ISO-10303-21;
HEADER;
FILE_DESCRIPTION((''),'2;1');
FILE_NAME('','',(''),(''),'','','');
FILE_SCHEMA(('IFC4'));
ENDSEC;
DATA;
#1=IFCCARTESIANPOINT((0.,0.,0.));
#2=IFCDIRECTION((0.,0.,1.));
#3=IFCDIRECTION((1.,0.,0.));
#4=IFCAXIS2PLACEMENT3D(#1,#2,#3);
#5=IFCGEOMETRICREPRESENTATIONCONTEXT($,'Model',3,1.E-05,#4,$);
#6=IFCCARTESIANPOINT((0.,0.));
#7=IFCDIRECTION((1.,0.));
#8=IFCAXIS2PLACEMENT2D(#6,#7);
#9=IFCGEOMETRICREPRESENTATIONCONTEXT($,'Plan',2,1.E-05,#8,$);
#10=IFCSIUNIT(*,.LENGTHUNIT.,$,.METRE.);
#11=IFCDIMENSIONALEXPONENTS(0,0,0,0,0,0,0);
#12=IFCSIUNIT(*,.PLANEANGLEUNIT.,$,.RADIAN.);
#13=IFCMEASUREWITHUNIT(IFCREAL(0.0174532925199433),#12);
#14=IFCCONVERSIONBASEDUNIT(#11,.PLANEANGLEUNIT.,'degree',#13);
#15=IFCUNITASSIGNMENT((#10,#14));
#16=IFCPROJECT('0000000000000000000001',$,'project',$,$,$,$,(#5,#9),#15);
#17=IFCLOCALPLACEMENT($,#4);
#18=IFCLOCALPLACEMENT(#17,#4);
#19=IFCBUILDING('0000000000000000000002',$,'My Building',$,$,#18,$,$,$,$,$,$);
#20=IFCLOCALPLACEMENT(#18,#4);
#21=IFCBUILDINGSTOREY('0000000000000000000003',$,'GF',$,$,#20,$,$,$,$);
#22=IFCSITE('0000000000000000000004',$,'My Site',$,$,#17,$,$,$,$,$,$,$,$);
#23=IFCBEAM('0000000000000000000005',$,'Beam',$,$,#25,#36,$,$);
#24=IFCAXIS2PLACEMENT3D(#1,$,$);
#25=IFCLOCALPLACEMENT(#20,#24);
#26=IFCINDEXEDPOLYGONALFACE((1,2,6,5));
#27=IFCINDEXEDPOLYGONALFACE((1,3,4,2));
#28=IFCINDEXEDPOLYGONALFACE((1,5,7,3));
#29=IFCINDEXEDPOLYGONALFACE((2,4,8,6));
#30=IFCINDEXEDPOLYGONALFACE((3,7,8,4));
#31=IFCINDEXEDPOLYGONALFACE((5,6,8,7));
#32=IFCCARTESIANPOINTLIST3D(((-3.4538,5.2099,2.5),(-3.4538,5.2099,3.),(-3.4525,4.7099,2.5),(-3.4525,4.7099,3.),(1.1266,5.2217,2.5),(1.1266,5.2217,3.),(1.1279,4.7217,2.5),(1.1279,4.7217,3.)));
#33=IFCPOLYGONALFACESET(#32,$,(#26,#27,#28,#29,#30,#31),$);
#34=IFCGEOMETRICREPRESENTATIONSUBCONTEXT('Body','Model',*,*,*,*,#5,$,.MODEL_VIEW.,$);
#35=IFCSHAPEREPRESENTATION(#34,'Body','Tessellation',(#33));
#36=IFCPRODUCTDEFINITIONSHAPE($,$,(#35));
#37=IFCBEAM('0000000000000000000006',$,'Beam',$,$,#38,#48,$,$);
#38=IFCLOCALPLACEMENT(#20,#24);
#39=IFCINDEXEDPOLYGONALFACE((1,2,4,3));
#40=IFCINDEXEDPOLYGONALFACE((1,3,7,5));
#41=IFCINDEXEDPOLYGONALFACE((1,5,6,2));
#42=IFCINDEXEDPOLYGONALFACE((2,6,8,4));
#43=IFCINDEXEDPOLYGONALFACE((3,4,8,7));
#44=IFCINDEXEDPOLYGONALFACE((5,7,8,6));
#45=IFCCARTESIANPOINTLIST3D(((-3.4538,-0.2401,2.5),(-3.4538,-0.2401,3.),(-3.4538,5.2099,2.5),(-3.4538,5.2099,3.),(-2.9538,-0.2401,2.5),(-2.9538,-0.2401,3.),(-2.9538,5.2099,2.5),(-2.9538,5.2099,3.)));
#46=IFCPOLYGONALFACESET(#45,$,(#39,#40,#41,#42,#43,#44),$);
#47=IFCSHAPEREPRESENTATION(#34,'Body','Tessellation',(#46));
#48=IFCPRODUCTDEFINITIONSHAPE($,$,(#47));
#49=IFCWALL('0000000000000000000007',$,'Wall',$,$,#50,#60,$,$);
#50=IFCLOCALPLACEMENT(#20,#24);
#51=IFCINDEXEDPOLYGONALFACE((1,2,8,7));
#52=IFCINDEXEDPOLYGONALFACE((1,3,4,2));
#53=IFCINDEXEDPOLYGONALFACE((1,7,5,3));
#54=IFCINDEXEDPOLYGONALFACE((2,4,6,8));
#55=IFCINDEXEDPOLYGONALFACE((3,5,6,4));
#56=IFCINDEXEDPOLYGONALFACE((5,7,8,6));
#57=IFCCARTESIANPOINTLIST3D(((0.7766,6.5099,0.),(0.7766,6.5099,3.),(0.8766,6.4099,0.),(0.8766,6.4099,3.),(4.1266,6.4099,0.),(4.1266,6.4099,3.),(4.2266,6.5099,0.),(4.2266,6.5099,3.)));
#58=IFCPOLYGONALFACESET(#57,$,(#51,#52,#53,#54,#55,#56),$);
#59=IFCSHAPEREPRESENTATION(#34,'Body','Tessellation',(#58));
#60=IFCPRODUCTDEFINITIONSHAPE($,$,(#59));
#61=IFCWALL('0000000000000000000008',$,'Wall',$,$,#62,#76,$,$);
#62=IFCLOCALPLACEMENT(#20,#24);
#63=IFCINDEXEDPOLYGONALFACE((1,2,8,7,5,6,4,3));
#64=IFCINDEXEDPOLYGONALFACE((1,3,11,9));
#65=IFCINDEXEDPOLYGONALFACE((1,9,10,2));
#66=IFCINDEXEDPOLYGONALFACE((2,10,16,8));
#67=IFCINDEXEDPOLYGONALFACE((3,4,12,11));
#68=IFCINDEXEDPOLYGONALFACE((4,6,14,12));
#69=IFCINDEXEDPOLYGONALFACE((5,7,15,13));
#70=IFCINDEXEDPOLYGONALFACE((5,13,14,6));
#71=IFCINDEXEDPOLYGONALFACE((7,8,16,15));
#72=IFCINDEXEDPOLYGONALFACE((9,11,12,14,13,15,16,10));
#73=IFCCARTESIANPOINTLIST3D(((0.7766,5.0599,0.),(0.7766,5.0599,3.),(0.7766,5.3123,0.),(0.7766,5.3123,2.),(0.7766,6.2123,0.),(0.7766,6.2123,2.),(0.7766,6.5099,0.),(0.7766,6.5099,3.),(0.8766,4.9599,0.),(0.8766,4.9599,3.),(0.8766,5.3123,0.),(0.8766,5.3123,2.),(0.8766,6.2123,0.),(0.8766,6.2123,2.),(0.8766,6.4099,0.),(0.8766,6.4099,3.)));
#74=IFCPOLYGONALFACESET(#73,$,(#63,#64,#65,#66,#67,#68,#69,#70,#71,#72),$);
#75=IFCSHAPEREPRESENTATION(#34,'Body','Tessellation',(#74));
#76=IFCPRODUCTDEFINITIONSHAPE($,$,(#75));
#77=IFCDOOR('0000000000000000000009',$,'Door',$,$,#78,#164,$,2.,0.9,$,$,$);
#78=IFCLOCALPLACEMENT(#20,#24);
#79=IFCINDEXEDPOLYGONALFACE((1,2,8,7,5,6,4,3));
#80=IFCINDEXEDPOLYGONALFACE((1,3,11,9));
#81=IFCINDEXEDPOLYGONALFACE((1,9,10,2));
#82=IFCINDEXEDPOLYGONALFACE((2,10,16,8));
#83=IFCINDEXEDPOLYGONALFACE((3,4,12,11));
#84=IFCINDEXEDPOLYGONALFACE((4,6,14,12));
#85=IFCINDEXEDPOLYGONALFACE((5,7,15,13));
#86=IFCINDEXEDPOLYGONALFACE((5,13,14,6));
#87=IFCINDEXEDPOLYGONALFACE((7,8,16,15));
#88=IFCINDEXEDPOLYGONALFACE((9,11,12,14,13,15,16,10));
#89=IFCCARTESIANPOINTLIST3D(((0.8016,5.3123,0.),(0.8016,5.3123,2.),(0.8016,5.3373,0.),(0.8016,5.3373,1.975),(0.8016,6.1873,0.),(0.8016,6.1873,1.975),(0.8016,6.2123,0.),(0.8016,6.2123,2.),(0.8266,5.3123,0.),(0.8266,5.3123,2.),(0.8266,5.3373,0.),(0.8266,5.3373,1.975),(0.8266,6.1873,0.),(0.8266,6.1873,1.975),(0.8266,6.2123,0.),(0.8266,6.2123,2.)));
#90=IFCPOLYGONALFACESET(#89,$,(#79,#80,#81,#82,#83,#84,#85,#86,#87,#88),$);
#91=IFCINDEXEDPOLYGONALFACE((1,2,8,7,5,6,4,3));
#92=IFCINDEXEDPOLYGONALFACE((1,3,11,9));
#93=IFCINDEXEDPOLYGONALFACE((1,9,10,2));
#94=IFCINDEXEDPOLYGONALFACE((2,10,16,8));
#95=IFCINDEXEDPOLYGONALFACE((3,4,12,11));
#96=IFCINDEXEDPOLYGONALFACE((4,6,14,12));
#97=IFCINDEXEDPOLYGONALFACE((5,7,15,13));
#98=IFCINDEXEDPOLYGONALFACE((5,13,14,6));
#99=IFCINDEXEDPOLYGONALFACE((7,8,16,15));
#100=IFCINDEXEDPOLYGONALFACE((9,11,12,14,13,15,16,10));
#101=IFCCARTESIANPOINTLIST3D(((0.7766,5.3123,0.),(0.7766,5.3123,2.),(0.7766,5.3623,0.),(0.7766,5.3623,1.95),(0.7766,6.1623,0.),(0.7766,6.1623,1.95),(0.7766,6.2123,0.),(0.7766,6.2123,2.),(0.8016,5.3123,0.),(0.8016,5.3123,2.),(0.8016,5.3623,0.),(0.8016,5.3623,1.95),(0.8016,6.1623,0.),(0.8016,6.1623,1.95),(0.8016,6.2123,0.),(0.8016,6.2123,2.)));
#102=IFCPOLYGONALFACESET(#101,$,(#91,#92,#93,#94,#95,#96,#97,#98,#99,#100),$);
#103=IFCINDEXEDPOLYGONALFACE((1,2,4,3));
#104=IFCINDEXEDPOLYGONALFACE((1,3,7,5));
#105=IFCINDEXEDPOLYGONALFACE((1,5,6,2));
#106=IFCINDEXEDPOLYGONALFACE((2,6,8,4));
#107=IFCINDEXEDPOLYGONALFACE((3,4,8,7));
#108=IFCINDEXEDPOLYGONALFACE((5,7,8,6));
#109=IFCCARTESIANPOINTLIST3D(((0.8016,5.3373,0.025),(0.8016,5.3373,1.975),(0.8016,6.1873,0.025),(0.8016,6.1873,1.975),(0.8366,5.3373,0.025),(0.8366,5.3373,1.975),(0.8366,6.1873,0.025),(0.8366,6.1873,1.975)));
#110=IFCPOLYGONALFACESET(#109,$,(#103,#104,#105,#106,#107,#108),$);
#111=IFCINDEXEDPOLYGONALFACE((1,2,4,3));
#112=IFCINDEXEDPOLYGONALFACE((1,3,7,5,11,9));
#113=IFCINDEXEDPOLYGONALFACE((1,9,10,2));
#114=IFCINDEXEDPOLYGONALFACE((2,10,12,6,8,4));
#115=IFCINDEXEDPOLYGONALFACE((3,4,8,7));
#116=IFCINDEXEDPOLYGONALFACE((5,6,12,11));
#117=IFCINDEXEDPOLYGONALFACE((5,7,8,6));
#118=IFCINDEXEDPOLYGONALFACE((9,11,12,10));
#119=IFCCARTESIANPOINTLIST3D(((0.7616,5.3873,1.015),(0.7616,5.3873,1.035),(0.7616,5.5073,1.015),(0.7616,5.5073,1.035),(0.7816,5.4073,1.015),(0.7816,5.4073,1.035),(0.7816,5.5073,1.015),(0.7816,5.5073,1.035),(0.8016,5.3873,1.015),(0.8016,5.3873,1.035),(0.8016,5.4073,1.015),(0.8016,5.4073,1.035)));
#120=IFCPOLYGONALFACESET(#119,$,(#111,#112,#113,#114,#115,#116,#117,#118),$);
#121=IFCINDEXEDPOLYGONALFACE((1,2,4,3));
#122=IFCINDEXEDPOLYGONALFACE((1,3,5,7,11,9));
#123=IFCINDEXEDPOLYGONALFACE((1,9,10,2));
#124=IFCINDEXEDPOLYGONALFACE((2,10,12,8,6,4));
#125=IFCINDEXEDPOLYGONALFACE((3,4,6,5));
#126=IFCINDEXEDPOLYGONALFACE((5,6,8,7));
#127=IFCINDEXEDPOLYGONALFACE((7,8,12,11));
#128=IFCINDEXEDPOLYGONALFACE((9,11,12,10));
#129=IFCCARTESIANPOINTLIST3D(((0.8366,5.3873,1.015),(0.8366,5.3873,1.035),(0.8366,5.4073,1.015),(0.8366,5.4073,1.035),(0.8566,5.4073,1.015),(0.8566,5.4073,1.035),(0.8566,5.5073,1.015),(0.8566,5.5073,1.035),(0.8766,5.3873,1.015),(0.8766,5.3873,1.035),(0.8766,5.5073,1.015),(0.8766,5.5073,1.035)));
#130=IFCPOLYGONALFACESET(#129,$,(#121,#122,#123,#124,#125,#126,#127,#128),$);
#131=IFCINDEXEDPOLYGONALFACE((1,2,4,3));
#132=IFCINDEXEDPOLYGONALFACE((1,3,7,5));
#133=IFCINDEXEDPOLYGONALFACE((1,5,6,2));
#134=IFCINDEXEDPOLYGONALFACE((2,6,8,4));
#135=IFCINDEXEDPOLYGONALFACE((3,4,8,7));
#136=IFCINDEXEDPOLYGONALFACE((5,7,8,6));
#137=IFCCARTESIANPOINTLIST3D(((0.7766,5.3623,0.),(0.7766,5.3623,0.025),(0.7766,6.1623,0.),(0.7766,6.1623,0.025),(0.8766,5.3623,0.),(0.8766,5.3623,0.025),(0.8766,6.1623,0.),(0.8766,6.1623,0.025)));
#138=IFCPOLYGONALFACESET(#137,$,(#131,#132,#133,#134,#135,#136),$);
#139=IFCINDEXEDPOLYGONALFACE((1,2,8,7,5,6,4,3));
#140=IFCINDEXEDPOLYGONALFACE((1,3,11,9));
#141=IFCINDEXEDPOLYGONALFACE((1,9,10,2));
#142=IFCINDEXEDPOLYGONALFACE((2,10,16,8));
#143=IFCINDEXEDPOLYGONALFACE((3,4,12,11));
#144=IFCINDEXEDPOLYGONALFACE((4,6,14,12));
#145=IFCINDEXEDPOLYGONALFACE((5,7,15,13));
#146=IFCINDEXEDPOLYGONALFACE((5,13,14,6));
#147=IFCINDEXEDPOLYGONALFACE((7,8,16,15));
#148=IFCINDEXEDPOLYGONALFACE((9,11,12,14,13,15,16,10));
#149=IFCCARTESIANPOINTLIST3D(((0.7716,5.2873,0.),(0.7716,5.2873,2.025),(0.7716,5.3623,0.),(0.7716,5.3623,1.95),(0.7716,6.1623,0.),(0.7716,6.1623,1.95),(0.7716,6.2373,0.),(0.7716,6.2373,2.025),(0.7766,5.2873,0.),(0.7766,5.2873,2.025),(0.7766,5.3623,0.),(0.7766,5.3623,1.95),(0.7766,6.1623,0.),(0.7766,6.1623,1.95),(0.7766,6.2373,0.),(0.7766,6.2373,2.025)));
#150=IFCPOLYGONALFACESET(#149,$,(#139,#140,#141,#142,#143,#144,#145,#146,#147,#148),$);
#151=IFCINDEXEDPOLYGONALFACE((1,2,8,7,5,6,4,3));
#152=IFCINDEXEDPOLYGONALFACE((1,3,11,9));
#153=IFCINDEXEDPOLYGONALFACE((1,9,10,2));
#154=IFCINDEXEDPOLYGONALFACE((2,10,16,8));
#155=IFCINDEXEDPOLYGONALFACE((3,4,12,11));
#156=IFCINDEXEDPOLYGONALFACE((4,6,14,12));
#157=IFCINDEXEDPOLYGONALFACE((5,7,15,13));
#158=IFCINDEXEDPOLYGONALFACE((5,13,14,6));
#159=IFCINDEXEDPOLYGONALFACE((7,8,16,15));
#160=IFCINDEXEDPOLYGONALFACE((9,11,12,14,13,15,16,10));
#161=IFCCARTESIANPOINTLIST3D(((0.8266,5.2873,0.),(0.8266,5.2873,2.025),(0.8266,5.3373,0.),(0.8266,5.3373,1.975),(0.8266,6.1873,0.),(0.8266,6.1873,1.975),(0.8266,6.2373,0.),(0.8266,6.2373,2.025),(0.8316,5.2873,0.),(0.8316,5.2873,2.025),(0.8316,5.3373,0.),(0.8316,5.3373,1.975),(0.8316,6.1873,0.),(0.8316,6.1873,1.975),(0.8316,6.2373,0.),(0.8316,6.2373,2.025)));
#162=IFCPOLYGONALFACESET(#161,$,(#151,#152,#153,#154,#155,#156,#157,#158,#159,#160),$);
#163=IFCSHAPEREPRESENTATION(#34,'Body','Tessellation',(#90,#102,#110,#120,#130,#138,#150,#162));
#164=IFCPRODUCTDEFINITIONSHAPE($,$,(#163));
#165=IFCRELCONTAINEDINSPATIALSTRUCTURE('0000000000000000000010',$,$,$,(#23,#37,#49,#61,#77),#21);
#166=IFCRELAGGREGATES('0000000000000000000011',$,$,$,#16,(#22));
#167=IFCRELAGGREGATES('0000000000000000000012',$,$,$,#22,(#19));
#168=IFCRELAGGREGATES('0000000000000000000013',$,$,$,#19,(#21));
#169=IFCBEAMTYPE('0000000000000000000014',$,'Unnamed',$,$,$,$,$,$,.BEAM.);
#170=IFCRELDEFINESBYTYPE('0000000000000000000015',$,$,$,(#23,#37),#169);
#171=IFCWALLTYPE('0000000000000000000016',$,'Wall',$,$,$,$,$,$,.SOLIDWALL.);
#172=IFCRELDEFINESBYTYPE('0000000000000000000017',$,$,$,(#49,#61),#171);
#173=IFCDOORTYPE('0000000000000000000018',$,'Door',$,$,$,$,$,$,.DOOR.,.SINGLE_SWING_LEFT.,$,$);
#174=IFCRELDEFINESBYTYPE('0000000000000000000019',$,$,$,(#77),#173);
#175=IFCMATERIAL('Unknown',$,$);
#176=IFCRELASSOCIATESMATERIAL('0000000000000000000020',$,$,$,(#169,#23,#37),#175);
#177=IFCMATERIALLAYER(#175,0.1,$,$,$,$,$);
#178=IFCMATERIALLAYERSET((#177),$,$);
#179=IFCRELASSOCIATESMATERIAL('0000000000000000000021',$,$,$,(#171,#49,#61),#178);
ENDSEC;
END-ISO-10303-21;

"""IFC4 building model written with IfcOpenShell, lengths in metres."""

from ifc_helpers import new_model, entity, si_unit, converted_unit, frame, origin_with_axes, origin_2d_with_axis, place, context, subcontext, project, spatial, line, indexed_curve, rectangle, outline, extrude, shape, source, transform, mapped, material, layer, layer_set, layer_usage, material_profile, profile_set, profile_usage, type_object, type_shapes, element, fill, save


model = new_model("IFC4")

# Units and contexts
model_context = context("Model", 3, precision=1e-05, world=origin_with_axes())
plan_context = context("Plan", 2, precision=1e-05, world=origin_2d_with_axis())
body_context_1 = subcontext(model_context, "Body", "Model", "MODEL_VIEW")
body_context_2 = subcontext(plan_context, "Body", "Plan", "PLAN_VIEW")
ifc_project = project(units=[si_unit("LENGTHUNIT", "METRE"), converted_unit("PLANEANGLEUNIT", "degree", entity("IfcReal", 0.0174532925199433), si_unit("PLANEANGLEUNIT", "RADIAN"), dimensions=[0, 0, 0, 0, 0, 0, 0])], contexts=[model_context, plan_context])

# Site, building, storey
site_placement = place(None, origin_with_axes())
site = spatial("IfcSite", under=ifc_project, at=site_placement, Name="My Site")
building_placement = place(site_placement, origin_with_axes())
building = spatial("IfcBuilding", under=site, at=building_placement, Name="My Building")
storey_placement = place(building_placement, origin_with_axes())
storey = spatial("IfcBuildingStorey", under=building, at=storey_placement, Name="GF")

# Shared definitions
ifc_material = material(Name="Unknown")

# Beams
ifc_material_profile_1 = material_profile(ifc_material, rectangle(XDim=0.5, YDim=0.5))
ifc_profile_set_1 = profile_set([ifc_material_profile_1])
beam_type = type_object("IfcBeamType", Name="Unnamed", PredefinedType="BEAM", material=ifc_profile_set_1)
ifc_profile_usage_1 = profile_usage(ifc_profile_set_1, cardinal=7)
beam_1_placement = place(storey_placement, frame((-3.4538, 5.2099, 3.0), z_axis=(0.999997, 0.002582, 0.0), x_axis=(-0.002582, 0.999997, 0.0)))
element("IfcBeam", 1, at=beam_1_placement, inside=storey, type_object=beam_type, material=ifc_profile_usage_1, Name="Beam", context=body_context_1, shape_type="SweptSolid", body=[
    extrude(rectangle(XDim=0.5, YDim=0.5), frame((-0.25, -0.25, 0.0), z_axis=(0.0, 0.0, 1.0), x_axis=(1.0, 0.0, 0.0)), (0.0, 0.0, 1.0), 4.5805),
])
ifc_profile_usage_2 = profile_usage(ifc_profile_set_1, cardinal=7)
beam_2_placement = place(storey_placement, frame((-2.9538, 5.2099, 3.0), z_axis=(0.0, -1.0, 0.0), x_axis=(1.0, 0.0, 0.0)))
element("IfcBeam", 2, at=beam_2_placement, inside=storey, type_object=beam_type, material=ifc_profile_usage_2, Name="Beam", context=body_context_1, shape_type="SweptSolid", body=[
    extrude(rectangle(XDim=0.5, YDim=0.5), frame((-0.25, -0.25, 0.0), z_axis=(0.0, 0.0, 1.0), x_axis=(1.0, 0.0, 0.0)), (0.0, 0.0, 1.0), 5.45),
])

# Wall
ifc_layer = layer(ifc_material, 0.1)
ifc_layer_set = layer_set([ifc_layer])
ifc_layer_usage_1 = layer_usage(ifc_layer_set, "AXIS2", "POSITIVE", 0.0)
wall_type = type_object("IfcWallType", Name="Wall", PredefinedType="SOLIDWALL", material=ifc_layer_set)
wall_1_placement = place(storey_placement, frame((4.2266, 6.5099, 0.0), z_axis=(0.0, 0.0, 1.0), x_axis=(-1.0, 0.0, 0.0)))
element("IfcWall", 3, at=wall_1_placement, inside=storey, type_object=wall_type, material=ifc_layer_usage_1, Name="Wall", context=body_context_1, shape_type="SweptSolid", body=[
    extrude(outline(indexed_curve([(0.0, 0.0), (0.1, 0.1), (3.35, 0.1), (3.45, 0.0)], segments=[line(1, 2, 3, 4, 1)])), origin_with_axes(), (0.0, 0.0, 1.0), 3.0),
])

# Wall, opening, door
ifc_layer_usage_2 = layer_usage(ifc_layer_set, "AXIS2", "POSITIVE", 0.0)
wall_2_placement = place(storey_placement, frame((0.7766, 6.5099, 0.0), z_axis=(0.0, 0.0, 1.0), x_axis=(0.0, -1.0, 0.0)))
wall_2 = element("IfcWall", 4, at=wall_2_placement, inside=storey, type_object=wall_type, material=ifc_layer_usage_2, Name="Wall", context=body_context_1, shape_type="SweptSolid", body=[
    extrude(outline(indexed_curve([(0.0, 0.0), (0.1, 0.1), (1.55, 0.1), (1.45, 0.0)], segments=[line(1, 2, 3, 4, 1)])), origin_with_axes(), (0.0, 0.0, 1.0), 3.0),
])
shared_shape_1 = source(origin_with_axes(), body_context_1, "Body", "SweptSolid", [
    extrude(outline(indexed_curve([(0.0, 0.0), (0.9, 0.0), (0.9, 2.0), (0.0, 2.0)], segments=[line(1, 2, 3, 4, 1)])), frame((0.0, -0.6, 0.0), z_axis=(0.0, -1.0, 0.0), x_axis=(1.0, 0.0, 0.0)), (0.0, 0.0, -1.0), 1.2),
])
opening_1_placement = place(wall_2_placement, frame((0.2976, 0.0, 0.0), z_axis=(0.0, 0.0, 1.0), x_axis=(1.0, 0.0, 0.0)))
opening_1 = element("IfcOpeningElement", 5, at=opening_1_placement, cuts=wall_2, PredefinedType="OPENING", context=body_context_1, shape_type="MappedRepresentation", body=[
    mapped(shared_shape_1, transform((0.0, 0.0, 0.0), x_axis=(1.0, 0.0, 0.0), y_axis=(0.0, 1.0, 0.0), z_axis=(0.0, 0.0, 1.0), scale=1.0)),
])
door_type = type_object("IfcDoorType", Name="Door", OperationType="SINGLE_SWING_LEFT", PredefinedType="DOOR")
shared_shape_2 = source(origin_with_axes(), body_context_1, "Body", "SweptSolid", [
    extrude(outline(indexed_curve([(0.0, 0.0), (0.0, 2.0), (0.9, 2.0), (0.9, 0.0), (0.875, 0.0), (0.875, 1.975), (0.025, 1.975), (0.025, 0.0)], segments=[line(1, 2, 3, 4, 5, 6, 7, 8, 1)])), frame((0.0, 0.025, 0.0), z_axis=(0.0, -1.0, 0.0), x_axis=(1.0, 0.0, 0.0)), (0.0, 0.0, -1.0), 0.025),
    extrude(outline(indexed_curve([(0.0, 0.0), (0.0, 2.0), (0.9, 2.0), (0.9, 0.0), (0.85, 0.0), (0.85, 1.95), (0.05, 1.95), (0.05, 0.0)], segments=[line(1, 2, 3, 4, 5, 6, 7, 8, 1)])), frame((0.0, 0.0, 0.0), z_axis=(0.0, -1.0, 0.0), x_axis=(1.0, 0.0, 0.0)), (0.0, 0.0, -1.0), 0.025),
    extrude(outline(indexed_curve([(0.0, 0.0), (0.85, 0.0), (0.85, 0.035), (0.0, 0.035)], segments=[line(1, 2, 3, 4, 1)])), frame((0.025, 0.025, 0.025), z_axis=(0.0, 0.0, 1.0), x_axis=(1.0, 0.0, 0.0)), (0.0, 0.0, 1.0), 1.95),
    extrude(outline(indexed_curve([(0.0, 0.0), (0.0, -0.04), (-0.12, -0.04), (-0.12, -0.02), (-0.02, -0.02), (-0.02, 0.0)], segments=[line(1, 2, 3, 4, 5, 6, 1)])), frame((0.825, 0.025, 1.015), z_axis=(0.0, 0.0, 1.0), x_axis=(1.0, 0.0, 0.0)), (0.0, 0.0, 1.0), 0.02),
    extrude(outline(indexed_curve([(0.0, 0.0), (0.0, 0.04), (-0.12, 0.04), (-0.12, 0.02), (-0.02, 0.02), (-0.02, 0.0)], segments=[line(1, 2, 3, 4, 5, 6, 1)])), frame((0.825, 0.06, 1.015), z_axis=(0.0, 0.0, 1.0), x_axis=(1.0, 0.0, 0.0)), (0.0, 0.0, 1.0), 0.02),
    extrude(outline(indexed_curve([(0.0, 0.0), (0.8, 0.0), (0.8, 0.1), (0.0, 0.1)], segments=[line(1, 2, 3, 4, 1)])), frame((0.05, 0.0, 0.0), z_axis=(0.0, 0.0, 1.0), x_axis=(1.0, 0.0, 0.0)), (0.0, 0.0, 1.0), 0.025),
    extrude(outline(indexed_curve([(0.0, 0.0), (0.0, 2.025), (0.95, 2.025), (0.95, 0.0), (0.875, 0.0), (0.875, 1.95), (0.075, 1.95), (0.075, 0.0)], segments=[line(1, 2, 3, 4, 5, 6, 7, 8, 1)])), frame((-0.025, -0.005, 0.0), z_axis=(0.0, -1.0, 0.0), x_axis=(1.0, 0.0, 0.0)), (0.0, 0.0, -1.0), 0.005),
    extrude(outline(indexed_curve([(0.0, 0.0), (0.0, 2.025), (0.95, 2.025), (0.95, 0.0), (0.9, 0.0), (0.9, 1.975), (0.05, 1.975), (0.05, 0.0)], segments=[line(1, 2, 3, 4, 5, 6, 7, 8, 1)])), frame((-0.025, 0.05, 0.0), z_axis=(0.0, -1.0, 0.0), x_axis=(1.0, 0.0, 0.0)), (0.0, 0.0, -1.0), 0.005),
])
shared_shape_3 = source(origin_with_axes(), body_context_2, "Body", "Curve2D", [
    entity("IfcIndexedPolyCurve", entity("IfcCartesianPointList2D", [[0.0, 0.0], [0.0, 0.05], [0.025, 0.05], [0.025, 0.025], [0.05, 0.025], [0.05, 0.0]]), [entity("IfcLineIndex", [1, 2, 3, 4, 5, 6, 1])]),
    entity("IfcIndexedPolyCurve", entity("IfcCartesianPointList2D", [[0.9, 0.0], [0.9, 0.05], [0.875, 0.05], [0.875, 0.025], [0.85, 0.025], [0.85, 0.0]]), [entity("IfcLineIndex", [1, 2, 3, 4, 5, 6, 1])]),
    entity("IfcTrimmedCurve", entity("IfcEllipse", entity("IfcAxis2Placement2D", entity("IfcCartesianPoint", [0.06, 0.05]), entity("IfcDirection", [1.0, 0.0])), 0.815, 0.85), [entity("IfcCartesianPoint", [0.875, 0.05])], [entity("IfcCartesianPoint", [0.06, 0.9])], True, "CARTESIAN"),
    entity("IfcIndexedPolyCurve", entity("IfcCartesianPointList2D", [[0.025, 0.05], [0.06, 0.05], [0.06, 0.9], [0.025, 0.9]]), [entity("IfcLineIndex", [1, 2, 3, 4, 1])]),
])
type_shapes(door_type, [shared_shape_2, shared_shape_3])
door_1_placement = place(opening_1_placement, frame((0.0, 0.0, 0.0), z_axis=(0.0, 0.0, 1.0), x_axis=(1.0, 0.0, 0.0)))
door_1 = element("IfcDoor", 6, at=door_1_placement, inside=storey, type_object=door_type, Name="Door", OverallHeight=2.0, OverallWidth=0.9, shapes=[
    shape(body_context_1, "Body", "MappedRepresentation", [mapped(shared_shape_2, transform((0.0, 0.0, 0.0), x_axis=(1.0, 0.0, 0.0), y_axis=(0.0, 1.0, 0.0), z_axis=(0.0, 0.0, 1.0), scale=1.0))]),
    shape(body_context_2, "Body", "MappedRepresentation", [mapped(shared_shape_3, transform((0.0, 0.0, 0.0), x_axis=(1.0, 0.0, 0.0), y_axis=(0.0, 1.0, 0.0), z_axis=(0.0, 0.0, 1.0), scale=1.0))]),
])
fill(opening_1, door_1)

save(model, "model.ifc")
